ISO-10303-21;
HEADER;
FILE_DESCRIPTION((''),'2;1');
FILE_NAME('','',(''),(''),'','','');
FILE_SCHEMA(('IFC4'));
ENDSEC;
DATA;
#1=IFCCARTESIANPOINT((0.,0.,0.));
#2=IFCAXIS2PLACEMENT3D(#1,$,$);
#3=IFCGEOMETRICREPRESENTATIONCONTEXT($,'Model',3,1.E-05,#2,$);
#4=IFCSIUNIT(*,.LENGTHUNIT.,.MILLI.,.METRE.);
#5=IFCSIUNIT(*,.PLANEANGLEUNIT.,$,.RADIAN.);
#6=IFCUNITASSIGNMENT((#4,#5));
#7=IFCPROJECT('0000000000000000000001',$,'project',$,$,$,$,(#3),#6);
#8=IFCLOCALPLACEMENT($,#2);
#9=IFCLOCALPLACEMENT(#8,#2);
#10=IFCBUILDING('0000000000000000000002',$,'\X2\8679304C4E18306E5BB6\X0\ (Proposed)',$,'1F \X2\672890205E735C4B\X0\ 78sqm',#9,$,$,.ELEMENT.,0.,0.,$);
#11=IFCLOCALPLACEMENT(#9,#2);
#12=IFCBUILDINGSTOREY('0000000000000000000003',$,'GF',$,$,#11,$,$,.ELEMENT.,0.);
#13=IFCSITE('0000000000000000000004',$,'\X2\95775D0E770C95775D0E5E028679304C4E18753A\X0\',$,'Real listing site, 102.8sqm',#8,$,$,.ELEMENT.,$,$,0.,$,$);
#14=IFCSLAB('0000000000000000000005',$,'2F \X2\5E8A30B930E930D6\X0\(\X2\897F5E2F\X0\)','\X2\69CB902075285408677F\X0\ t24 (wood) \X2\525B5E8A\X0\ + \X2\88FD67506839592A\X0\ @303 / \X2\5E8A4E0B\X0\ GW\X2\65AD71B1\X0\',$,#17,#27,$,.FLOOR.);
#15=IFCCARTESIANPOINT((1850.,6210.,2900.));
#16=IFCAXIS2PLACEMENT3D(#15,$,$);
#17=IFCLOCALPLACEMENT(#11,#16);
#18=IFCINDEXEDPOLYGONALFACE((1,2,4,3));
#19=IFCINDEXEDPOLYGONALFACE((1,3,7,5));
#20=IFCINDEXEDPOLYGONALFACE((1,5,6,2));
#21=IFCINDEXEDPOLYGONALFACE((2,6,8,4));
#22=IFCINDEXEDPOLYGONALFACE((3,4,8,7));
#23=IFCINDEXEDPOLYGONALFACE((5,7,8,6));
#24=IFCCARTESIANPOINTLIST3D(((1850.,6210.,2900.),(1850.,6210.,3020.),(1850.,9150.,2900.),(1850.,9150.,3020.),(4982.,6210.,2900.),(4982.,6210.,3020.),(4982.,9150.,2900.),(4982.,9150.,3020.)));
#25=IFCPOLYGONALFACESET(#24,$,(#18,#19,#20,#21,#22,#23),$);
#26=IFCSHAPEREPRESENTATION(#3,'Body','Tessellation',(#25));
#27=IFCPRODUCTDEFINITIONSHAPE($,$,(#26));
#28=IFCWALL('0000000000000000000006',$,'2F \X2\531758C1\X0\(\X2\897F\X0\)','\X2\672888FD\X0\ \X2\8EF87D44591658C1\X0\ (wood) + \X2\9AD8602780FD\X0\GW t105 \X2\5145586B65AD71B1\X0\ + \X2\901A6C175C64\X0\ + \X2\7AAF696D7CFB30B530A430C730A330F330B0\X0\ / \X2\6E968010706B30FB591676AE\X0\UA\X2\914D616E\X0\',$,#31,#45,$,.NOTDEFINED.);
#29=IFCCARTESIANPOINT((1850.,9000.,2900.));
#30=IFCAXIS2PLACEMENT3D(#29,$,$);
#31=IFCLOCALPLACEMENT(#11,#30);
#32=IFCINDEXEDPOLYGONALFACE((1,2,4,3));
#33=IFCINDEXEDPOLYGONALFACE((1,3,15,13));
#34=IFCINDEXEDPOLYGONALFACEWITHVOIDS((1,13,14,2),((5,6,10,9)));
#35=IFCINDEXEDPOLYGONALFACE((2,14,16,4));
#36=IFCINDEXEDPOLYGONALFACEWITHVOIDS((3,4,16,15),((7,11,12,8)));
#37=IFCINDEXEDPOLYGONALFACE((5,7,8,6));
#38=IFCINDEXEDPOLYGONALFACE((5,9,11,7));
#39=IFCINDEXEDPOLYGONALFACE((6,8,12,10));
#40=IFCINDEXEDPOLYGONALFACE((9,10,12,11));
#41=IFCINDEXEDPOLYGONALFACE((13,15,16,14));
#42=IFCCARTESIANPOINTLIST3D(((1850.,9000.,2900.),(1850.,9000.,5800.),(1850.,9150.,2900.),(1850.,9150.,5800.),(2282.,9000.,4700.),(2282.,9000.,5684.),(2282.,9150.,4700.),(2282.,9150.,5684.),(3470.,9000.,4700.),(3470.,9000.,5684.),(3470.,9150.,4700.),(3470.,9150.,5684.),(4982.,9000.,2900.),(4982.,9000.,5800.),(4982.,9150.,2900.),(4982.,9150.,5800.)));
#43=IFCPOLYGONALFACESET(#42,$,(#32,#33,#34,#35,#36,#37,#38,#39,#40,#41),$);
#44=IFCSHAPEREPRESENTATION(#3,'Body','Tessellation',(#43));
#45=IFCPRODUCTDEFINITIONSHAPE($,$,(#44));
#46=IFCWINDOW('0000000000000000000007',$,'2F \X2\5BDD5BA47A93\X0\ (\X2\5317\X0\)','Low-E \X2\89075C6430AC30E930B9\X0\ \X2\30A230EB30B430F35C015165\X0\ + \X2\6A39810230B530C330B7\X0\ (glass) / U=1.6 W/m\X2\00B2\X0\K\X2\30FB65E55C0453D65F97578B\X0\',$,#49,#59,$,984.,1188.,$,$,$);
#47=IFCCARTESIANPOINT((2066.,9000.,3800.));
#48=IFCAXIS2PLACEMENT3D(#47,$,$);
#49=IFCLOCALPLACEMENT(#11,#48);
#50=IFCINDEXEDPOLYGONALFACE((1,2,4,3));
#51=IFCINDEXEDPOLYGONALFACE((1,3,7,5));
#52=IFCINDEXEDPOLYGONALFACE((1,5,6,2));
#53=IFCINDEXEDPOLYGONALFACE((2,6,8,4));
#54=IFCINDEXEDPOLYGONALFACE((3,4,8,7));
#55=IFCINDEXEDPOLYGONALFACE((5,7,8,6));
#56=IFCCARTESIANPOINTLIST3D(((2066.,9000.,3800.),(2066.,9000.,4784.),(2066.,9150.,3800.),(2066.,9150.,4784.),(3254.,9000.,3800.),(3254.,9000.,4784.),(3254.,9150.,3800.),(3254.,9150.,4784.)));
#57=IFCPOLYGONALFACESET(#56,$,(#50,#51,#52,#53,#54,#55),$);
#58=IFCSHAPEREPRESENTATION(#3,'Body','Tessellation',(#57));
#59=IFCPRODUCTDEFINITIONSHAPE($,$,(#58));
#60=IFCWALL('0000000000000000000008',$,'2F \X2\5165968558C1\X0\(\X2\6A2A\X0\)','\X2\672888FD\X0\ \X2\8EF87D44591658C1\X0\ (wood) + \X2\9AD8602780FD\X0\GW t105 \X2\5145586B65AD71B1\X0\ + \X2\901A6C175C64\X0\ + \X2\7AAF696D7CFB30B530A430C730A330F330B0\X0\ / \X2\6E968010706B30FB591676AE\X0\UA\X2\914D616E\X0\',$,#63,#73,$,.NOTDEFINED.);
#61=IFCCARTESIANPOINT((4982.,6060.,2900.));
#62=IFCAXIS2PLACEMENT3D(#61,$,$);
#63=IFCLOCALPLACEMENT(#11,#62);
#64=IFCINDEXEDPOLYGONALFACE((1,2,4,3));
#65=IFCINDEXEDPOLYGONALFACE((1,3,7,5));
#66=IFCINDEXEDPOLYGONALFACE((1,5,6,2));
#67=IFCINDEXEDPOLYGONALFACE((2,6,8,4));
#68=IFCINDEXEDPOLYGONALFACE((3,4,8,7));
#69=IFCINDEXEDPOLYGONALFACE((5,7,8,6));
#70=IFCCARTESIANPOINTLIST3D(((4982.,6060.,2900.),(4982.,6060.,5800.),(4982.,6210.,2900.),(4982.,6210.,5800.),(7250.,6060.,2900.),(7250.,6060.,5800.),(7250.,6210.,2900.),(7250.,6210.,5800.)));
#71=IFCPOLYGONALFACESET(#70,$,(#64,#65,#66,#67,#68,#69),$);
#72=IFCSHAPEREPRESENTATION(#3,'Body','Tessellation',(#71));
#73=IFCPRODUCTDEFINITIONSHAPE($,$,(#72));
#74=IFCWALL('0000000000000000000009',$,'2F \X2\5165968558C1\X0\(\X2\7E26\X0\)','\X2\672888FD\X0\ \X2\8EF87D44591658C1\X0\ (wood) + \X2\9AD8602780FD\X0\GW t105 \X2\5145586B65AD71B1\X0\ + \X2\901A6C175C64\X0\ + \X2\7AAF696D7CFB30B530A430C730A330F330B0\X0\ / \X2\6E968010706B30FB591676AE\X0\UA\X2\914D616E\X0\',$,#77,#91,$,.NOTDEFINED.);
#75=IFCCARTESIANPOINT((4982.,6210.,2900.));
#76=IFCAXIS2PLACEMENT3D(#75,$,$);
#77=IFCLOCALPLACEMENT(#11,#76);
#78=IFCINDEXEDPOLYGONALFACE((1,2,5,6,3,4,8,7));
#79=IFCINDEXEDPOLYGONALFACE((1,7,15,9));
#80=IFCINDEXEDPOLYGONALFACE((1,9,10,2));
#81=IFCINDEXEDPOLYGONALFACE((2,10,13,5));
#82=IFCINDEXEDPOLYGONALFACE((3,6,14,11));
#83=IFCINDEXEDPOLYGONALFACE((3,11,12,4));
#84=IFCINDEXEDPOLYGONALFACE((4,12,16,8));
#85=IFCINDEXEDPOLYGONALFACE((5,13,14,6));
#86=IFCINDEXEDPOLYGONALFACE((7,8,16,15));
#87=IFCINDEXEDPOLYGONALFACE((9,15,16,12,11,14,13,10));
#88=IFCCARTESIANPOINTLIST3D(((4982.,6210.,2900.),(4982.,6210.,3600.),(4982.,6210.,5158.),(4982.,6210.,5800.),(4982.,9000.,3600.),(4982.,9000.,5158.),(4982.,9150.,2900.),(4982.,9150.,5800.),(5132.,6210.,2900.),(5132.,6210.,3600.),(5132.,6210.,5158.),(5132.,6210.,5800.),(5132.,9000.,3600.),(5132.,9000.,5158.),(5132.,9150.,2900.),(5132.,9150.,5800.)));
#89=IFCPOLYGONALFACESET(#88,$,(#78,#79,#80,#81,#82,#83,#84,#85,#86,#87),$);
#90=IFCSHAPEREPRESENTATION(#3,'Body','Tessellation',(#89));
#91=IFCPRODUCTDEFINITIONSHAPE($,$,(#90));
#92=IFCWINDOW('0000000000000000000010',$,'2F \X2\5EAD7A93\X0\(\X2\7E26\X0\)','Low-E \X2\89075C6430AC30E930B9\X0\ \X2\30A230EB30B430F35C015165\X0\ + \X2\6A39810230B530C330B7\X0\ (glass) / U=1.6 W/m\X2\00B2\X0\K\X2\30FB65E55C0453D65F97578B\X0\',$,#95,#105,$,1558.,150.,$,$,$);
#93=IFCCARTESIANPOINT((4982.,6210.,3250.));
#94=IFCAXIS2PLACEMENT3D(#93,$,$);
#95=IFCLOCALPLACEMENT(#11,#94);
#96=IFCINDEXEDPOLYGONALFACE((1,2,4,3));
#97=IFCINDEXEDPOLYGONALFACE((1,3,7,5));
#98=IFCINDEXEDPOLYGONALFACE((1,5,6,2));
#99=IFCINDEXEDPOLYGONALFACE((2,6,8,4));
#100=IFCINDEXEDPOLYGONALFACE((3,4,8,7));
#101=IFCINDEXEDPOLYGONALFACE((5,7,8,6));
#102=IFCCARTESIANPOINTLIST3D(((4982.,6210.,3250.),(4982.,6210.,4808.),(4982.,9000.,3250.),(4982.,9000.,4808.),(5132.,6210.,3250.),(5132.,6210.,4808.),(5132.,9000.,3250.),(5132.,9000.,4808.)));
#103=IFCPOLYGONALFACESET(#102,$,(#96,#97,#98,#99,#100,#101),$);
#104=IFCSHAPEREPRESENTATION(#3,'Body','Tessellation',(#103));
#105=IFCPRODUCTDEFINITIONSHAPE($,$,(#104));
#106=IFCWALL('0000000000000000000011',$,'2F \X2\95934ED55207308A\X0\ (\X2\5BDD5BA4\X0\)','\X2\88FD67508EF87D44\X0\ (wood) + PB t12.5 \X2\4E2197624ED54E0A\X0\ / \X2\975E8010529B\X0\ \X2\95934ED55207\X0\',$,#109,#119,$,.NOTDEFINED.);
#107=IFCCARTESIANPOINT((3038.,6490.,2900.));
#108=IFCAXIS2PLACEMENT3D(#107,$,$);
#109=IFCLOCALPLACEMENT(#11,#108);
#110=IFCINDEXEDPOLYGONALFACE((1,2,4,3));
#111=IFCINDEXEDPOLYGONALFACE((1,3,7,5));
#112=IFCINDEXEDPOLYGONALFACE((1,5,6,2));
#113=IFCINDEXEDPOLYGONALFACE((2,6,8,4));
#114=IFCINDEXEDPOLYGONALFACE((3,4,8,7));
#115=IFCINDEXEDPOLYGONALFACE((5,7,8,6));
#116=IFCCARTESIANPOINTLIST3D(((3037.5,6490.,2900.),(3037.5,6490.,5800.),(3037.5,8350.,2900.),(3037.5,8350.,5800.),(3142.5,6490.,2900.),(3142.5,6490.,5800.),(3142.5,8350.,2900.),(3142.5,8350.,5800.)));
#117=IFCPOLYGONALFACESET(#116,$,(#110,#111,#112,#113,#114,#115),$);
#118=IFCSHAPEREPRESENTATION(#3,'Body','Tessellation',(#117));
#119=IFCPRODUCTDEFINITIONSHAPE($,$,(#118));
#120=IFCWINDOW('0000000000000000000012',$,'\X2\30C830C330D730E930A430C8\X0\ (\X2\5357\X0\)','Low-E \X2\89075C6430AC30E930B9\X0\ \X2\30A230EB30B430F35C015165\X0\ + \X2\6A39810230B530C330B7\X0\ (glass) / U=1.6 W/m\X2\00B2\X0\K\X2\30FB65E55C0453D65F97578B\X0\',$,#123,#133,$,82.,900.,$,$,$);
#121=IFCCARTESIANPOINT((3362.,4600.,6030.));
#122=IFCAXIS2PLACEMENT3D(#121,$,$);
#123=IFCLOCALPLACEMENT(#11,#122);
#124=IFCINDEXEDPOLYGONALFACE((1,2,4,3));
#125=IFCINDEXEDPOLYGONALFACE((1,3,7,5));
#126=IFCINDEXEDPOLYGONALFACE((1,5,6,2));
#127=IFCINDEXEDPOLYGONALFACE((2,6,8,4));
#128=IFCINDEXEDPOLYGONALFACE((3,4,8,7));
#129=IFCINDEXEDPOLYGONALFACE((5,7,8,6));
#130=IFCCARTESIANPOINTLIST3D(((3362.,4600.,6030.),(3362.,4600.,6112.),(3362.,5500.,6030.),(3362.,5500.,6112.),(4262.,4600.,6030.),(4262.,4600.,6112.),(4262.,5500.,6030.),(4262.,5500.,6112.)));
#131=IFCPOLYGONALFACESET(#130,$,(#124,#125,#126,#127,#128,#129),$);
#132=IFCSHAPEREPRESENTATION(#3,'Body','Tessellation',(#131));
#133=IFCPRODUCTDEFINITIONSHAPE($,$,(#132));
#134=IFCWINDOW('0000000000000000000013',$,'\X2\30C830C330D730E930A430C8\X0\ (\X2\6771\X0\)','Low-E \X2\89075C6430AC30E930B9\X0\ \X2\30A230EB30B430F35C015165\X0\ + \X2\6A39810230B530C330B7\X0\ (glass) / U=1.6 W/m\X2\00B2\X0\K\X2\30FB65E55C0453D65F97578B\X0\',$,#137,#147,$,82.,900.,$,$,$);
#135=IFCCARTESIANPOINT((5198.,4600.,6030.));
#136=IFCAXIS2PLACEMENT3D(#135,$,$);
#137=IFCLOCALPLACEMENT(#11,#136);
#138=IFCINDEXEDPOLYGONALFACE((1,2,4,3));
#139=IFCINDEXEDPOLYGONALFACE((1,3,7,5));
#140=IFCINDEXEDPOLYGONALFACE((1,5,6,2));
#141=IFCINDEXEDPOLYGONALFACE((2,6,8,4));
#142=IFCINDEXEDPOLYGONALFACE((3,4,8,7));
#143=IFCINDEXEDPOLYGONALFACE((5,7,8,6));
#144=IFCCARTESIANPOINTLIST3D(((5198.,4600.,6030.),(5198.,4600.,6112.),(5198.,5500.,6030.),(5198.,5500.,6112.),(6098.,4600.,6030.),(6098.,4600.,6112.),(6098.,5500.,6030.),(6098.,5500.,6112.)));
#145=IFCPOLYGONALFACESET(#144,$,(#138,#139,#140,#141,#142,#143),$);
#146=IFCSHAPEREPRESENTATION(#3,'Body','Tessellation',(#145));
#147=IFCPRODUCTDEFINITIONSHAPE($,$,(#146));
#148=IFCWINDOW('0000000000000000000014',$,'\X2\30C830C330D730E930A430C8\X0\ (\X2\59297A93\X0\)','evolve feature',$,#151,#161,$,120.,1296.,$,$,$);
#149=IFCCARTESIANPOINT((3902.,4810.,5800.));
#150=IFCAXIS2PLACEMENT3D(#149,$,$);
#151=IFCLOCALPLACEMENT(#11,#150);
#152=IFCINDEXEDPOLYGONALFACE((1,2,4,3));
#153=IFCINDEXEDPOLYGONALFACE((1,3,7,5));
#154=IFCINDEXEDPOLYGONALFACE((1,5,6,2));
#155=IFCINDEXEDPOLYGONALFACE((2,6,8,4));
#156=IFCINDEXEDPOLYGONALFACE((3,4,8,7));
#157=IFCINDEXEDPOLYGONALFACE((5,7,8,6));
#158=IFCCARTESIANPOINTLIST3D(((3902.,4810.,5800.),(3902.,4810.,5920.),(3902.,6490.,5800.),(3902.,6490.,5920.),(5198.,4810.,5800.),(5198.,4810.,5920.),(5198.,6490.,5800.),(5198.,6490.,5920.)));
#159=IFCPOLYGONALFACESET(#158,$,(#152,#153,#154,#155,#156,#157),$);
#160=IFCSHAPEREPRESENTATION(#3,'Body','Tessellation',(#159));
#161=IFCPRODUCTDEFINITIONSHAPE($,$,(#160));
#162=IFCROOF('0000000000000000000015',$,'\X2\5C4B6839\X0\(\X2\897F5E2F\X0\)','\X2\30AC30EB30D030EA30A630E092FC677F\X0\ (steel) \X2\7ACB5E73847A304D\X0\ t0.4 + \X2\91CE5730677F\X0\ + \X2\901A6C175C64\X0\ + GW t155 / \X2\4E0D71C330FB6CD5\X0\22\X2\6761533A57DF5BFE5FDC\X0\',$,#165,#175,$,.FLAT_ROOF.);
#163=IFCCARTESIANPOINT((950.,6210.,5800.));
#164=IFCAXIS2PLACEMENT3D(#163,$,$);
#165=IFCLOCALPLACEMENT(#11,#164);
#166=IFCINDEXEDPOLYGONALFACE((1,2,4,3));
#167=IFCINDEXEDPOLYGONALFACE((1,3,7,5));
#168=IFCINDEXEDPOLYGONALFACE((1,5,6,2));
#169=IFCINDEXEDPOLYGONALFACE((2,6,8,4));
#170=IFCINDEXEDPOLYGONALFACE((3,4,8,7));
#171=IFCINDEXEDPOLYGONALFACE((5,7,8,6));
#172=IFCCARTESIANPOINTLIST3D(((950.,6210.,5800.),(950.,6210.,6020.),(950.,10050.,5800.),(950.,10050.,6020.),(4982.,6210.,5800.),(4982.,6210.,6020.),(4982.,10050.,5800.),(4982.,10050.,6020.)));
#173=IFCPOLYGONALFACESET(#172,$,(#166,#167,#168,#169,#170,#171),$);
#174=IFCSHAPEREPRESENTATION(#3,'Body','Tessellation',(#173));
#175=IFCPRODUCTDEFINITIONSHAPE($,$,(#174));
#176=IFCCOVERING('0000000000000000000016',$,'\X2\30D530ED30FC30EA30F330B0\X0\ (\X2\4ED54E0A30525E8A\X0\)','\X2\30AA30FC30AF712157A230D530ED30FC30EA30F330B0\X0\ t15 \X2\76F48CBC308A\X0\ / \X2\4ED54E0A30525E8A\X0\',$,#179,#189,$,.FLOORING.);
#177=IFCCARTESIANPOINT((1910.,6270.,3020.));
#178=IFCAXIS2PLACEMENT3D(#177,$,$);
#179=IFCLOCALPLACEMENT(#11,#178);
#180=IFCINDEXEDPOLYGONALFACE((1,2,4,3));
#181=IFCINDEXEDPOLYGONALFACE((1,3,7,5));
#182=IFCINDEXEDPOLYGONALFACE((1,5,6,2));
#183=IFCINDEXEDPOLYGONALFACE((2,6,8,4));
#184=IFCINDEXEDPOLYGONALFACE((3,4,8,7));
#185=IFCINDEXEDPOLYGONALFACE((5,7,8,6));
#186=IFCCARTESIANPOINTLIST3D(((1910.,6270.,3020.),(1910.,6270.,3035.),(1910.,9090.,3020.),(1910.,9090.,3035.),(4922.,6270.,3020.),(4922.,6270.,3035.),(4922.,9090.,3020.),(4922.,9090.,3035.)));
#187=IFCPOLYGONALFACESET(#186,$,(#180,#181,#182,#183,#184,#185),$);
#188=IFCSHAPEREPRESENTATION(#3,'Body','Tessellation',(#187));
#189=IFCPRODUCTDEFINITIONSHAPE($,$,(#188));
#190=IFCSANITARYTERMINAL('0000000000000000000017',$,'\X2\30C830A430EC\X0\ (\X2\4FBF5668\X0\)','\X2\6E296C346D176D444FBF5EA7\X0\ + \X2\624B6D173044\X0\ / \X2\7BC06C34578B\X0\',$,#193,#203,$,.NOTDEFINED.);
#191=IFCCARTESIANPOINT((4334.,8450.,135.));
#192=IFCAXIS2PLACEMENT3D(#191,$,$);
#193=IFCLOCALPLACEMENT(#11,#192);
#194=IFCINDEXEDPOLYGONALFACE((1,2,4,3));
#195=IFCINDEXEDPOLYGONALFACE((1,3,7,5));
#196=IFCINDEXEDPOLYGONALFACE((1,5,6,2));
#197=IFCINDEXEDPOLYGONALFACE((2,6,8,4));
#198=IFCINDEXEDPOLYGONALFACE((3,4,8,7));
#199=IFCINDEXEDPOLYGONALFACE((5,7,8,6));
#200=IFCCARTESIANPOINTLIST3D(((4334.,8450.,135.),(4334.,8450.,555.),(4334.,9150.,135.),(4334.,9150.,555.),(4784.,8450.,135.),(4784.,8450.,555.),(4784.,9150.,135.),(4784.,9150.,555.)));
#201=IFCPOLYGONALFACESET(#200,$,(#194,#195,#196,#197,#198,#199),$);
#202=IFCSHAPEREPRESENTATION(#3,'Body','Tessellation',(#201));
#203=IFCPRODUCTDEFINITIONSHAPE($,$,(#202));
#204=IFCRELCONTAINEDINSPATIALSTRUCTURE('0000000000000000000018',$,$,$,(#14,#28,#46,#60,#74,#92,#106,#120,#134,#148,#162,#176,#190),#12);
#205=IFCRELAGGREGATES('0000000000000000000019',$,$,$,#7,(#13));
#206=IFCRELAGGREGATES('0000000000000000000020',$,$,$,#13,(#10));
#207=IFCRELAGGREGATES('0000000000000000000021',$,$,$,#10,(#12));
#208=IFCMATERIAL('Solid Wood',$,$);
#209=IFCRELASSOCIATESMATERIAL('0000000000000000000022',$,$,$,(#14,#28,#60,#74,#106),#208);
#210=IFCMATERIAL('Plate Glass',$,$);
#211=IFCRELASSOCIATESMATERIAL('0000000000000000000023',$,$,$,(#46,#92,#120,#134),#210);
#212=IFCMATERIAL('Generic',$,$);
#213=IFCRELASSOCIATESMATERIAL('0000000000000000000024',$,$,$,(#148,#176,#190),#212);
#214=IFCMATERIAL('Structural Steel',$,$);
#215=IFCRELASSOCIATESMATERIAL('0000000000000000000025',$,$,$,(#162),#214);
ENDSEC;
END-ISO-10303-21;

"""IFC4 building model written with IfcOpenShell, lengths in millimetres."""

from ifc_helpers import new_model, si_unit, frame, frame_2d, origin, place, context, project, spatial, rectangle, extrude, material, element, fill, save


model = new_model("IFC4")

# Units and contexts
model_context = context("Model", 3, precision=1e-05, world=origin())
ifc_project = project(units=[si_unit("LENGTHUNIT", "METRE", prefix="MILLI"), si_unit("PLANEANGLEUNIT", "RADIAN")], contexts=[model_context])

# Site, building, storey
site_placement = place(None, origin())
site = spatial("IfcSite", under=ifc_project, at=site_placement, Name="長崎県長崎市虹が丘町", ObjectType="Real listing site, 102.8sqm", CompositionType="ELEMENT", RefElevation=0.0)
building_placement = place(site_placement, origin())
building = spatial("IfcBuilding", under=site, at=building_placement, Name="虹が丘の家 (Proposed)", ObjectType="1F 木造平屋 78sqm", CompositionType="ELEMENT", ElevationOfRefHeight=0.0, ElevationOfTerrain=0.0)
storey_placement = place(building_placement, origin())
storey = spatial("IfcBuildingStorey", under=building, at=storey_placement, Name="GF", CompositionType="ELEMENT", Elevation=0.0)

# Slab
ifc_material_1 = material(Name="Solid Wood")
slab_placement = place(storey_placement, frame((1850.0, 6210.0, 2900.0)))
element("IfcSlab", 1, at=slab_placement, inside=storey, material=ifc_material_1, Name="2F 床スラブ(西帯)", Description="構造用合板 t24 (wood) 剛床 + 製材根太 @303 / 床下 GW断熱", PredefinedType="FLOOR", context=model_context, shape_type="SweptSolid", body=[
    extrude(rectangle(XDim=3132.0, YDim=2940.0, at=frame_2d((1566.0, 1470.0))), frame((1850.0, 6210.0, 2900.0)), (0.0, 0.0, 1.0), 120.0),
])

# Wall, opening, window
wall_1_placement = place(storey_placement, frame((1850.0, 9000.0, 2900.0)))
wall_1 = element("IfcWall", 2, at=wall_1_placement, inside=storey, material=ifc_material_1, Name="2F 北壁(西)", Description="木製 軸組外壁 (wood) + 高性能GW t105 充填断熱 + 通気層 + 窯業系サイディング / 準耐火・外皮UA配慮", PredefinedType="NOTDEFINED", context=model_context, shape_type="SweptSolid", body=[
    extrude(rectangle(XDim=3132.0, YDim=150.0, at=frame_2d((1566.0, 75.0))), frame((1850.0, 9000.0, 2900.0)), (0.0, 0.0, 1.0), 2900.0),
])
opening_1_placement = place(storey_placement, frame((2066.0, 9000.0, 3800.0)))
opening_1 = element("IfcOpeningElement", 3, at=opening_1_placement, cuts=wall_1, PredefinedType="NOTDEFINED", context=model_context, shape_type="SweptSolid", body=[
    extrude(rectangle(XDim=1188.0, YDim=150.0, at=frame_2d((594.0, 75.0))), frame((2066.0, 9000.0, 3800.0)), (0.0, 0.0, 1.0), 984.0),
])
ifc_material_2 = material(Name="Plate Glass")
window_1_placement = place(storey_placement, frame((2066.0, 9000.0, 3800.0)))
window_1 = element("IfcWindow", 4, at=window_1_placement, inside=storey, material=ifc_material_2, Name="2F 寝室窓 (北)", Description="Low-E 複層ガラス アルゴン封入 + 樹脂サッシ (glass) / U=1.6 W/m²K・日射取得型", OverallHeight=984.0, OverallWidth=1188.0, context=model_context, shape_type="SweptSolid", body=[
    extrude(rectangle(XDim=1188.0, YDim=150.0, at=frame_2d((594.0, 75.0))), frame((2066.0, 9000.0, 3800.0)), (0.0, 0.0, 1.0), 984.0),
])
fill(opening_1, window_1)

# Wall
wall_2_placement = place(storey_placement, frame((4982.0, 6060.0, 2900.0)))
element("IfcWall", 5, at=wall_2_placement, inside=storey, material=ifc_material_1, Name="2F 入隅壁(横)", Description="木製 軸組外壁 (wood) + 高性能GW t105 充填断熱 + 通気層 + 窯業系サイディング / 準耐火・外皮UA配慮", PredefinedType="NOTDEFINED", context=model_context, shape_type="SweptSolid", body=[
    extrude(rectangle(XDim=2268.0, YDim=150.0, at=frame_2d((1134.0, 75.0))), frame((4982.0, 6060.0, 2900.0)), (0.0, 0.0, 1.0), 2900.0),
])

# Wall, opening, window
wall_3_placement = place(storey_placement, frame((4982.0, 6210.0, 2900.0)))
wall_3 = element("IfcWall", 6, at=wall_3_placement, inside=storey, material=ifc_material_1, Name="2F 入隅壁(縦)", Description="木製 軸組外壁 (wood) + 高性能GW t105 充填断熱 + 通気層 + 窯業系サイディング / 準耐火・外皮UA配慮", PredefinedType="NOTDEFINED", context=model_context, shape_type="SweptSolid", body=[
    extrude(rectangle(XDim=150.0, YDim=2940.0, at=frame_2d((75.0, 1470.0))), frame((4982.0, 6210.0, 2900.0)), (0.0, 0.0, 1.0), 2900.0),
])
opening_2_placement = place(storey_placement, frame((4982.0, 6210.0, 3250.0)))
opening_2 = element("IfcOpeningElement", 7, at=opening_2_placement, cuts=wall_3, PredefinedType="NOTDEFINED", context=model_context, shape_type="SweptSolid", body=[
    extrude(rectangle(XDim=150.0, YDim=2790.0, at=frame_2d((75.0, 1395.0))), frame((4982.0, 6210.0, 3250.0)), (0.0, 0.0, 1.0), 1558.0),
])
window_2_placement = place(storey_placement, frame((4982.0, 6210.0, 3250.0)))
window_2 = element("IfcWindow", 8, at=window_2_placement, inside=storey, material=ifc_material_2, Name="2F 庭窓(縦)", Description="Low-E 複層ガラス アルゴン封入 + 樹脂サッシ (glass) / U=1.6 W/m²K・日射取得型", OverallHeight=1558.0, OverallWidth=150.0, context=model_context, shape_type="SweptSolid", body=[
    extrude(rectangle(XDim=150.0, YDim=2790.0, at=frame_2d((75.0, 1395.0))), frame((4982.0, 6210.0, 3250.0)), (0.0, 0.0, 1.0), 1558.0),
])
fill(opening_2, window_2)

# Wall
wall_4_placement = place(storey_placement, frame((3038.0, 6490.0, 2900.0)))
element("IfcWall", 9, at=wall_4_placement, inside=storey, material=ifc_material_1, Name="2F 間仕切り (寝室)", Description="製材軸組 (wood) + PB t12.5 両面仕上 / 非耐力 間仕切", PredefinedType="NOTDEFINED", context=model_context, shape_type="SweptSolid", body=[
    extrude(rectangle(XDim=105.0, YDim=1860.0, at=frame_2d((52.0, 930.0))), frame((3038.0, 6490.0, 2900.0)), (0.0, 0.0, 1.0), 2900.0),
])

# Windows
window_3_placement = place(storey_placement, frame((3362.0, 4600.0, 6030.0)))
element("IfcWindow", 10, at=window_3_placement, inside=storey, material=ifc_material_2, Name="トップライト (南)", Description="Low-E 複層ガラス アルゴン封入 + 樹脂サッシ (glass) / U=1.6 W/m²K・日射取得型", OverallHeight=82.0, OverallWidth=900.0, context=model_context, shape_type="SweptSolid", body=[
    extrude(rectangle(XDim=900.0, YDim=900.0, at=frame_2d((450.0, 450.0))), frame((3362.0, 4600.0, 6030.0)), (0.0, 0.0, 1.0), 82.0),
])
window_4_placement = place(storey_placement, frame((5198.0, 4600.0, 6030.0)))
element("IfcWindow", 11, at=window_4_placement, inside=storey, material=ifc_material_2, Name="トップライト (東)", Description="Low-E 複層ガラス アルゴン封入 + 樹脂サッシ (glass) / U=1.6 W/m²K・日射取得型", OverallHeight=82.0, OverallWidth=900.0, context=model_context, shape_type="SweptSolid", body=[
    extrude(rectangle(XDim=900.0, YDim=900.0, at=frame_2d((450.0, 450.0))), frame((5198.0, 4600.0, 6030.0)), (0.0, 0.0, 1.0), 82.0),
])
ifc_material_3 = material(Name="Generic")
window_5_placement = place(storey_placement, frame((3902.0, 4810.0, 5800.0)))
element("IfcWindow", 12, at=window_5_placement, inside=storey, material=ifc_material_3, Name="トップライト (天窓)", Description="evolve feature", OverallHeight=120.0, OverallWidth=1296.0, context=model_context, shape_type="SweptSolid", body=[
    extrude(rectangle(XDim=1296.0, YDim=1680.0, at=frame_2d((648.0, 840.0))), frame((3902.0, 4810.0, 5800.0)), (0.0, 0.0, 1.0), 120.0),
])

# Roof
ifc_material_4 = material(Name="Structural Steel")
for number, where, name in (
    (13, (950.0, 6210.0, 5800.0), "屋根(西帯)"),
):
    element("IfcRoof", number, at=place(storey_placement, frame(where)), inside=storey, material=ifc_material_4, Name=name, Description="ガルバリウム鋼板 (steel) 立平葺き t0.4 + 野地板 + 通気層 + GW t155 / 不燃・法22条区域対応", PredefinedType="FLAT_ROOF", context=model_context, shape_type="SweptSolid", body=[
        extrude(rectangle(XDim=4032.0, YDim=3840.0, at=frame_2d((2016.0, 1920.0))), frame((950.0, 6210.0, 5800.0)), (0.0, 0.0, 1.0), 220.0),
    ])

# Covering
covering_placement = place(storey_placement, frame((1910.0, 6270.0, 3020.0)))
element("IfcCovering", 14, at=covering_placement, inside=storey, material=ifc_material_3, Name="フローリング (仕上げ床)", Description="オーク無垢フローリング t15 直貼り / 仕上げ床", PredefinedType="FLOORING", context=model_context, shape_type="SweptSolid", body=[
    extrude(rectangle(XDim=3012.0, YDim=2820.0, at=frame_2d((1506.0, 1410.0))), frame((1910.0, 6270.0, 3020.0)), (0.0, 0.0, 1.0), 15.0),
])

# Sanitary terminal
sanitary_terminal_placement = place(storey_placement, frame((4334.0, 8450.0, 135.0)))
element("IfcSanitaryTerminal", 15, at=sanitary_terminal_placement, inside=storey, material=ifc_material_3, Name="トイレ (便器)", Description="温水洗浄便座 + 手洗い / 節水型", PredefinedType="NOTDEFINED", context=model_context, shape_type="SweptSolid", body=[
    extrude(rectangle(XDim=450.0, YDim=700.0, at=frame_2d((225.0, 350.0))), frame((4334.0, 8450.0, 135.0)), (0.0, 0.0, 1.0), 420.0),
])

save(model, "model.ifc")
